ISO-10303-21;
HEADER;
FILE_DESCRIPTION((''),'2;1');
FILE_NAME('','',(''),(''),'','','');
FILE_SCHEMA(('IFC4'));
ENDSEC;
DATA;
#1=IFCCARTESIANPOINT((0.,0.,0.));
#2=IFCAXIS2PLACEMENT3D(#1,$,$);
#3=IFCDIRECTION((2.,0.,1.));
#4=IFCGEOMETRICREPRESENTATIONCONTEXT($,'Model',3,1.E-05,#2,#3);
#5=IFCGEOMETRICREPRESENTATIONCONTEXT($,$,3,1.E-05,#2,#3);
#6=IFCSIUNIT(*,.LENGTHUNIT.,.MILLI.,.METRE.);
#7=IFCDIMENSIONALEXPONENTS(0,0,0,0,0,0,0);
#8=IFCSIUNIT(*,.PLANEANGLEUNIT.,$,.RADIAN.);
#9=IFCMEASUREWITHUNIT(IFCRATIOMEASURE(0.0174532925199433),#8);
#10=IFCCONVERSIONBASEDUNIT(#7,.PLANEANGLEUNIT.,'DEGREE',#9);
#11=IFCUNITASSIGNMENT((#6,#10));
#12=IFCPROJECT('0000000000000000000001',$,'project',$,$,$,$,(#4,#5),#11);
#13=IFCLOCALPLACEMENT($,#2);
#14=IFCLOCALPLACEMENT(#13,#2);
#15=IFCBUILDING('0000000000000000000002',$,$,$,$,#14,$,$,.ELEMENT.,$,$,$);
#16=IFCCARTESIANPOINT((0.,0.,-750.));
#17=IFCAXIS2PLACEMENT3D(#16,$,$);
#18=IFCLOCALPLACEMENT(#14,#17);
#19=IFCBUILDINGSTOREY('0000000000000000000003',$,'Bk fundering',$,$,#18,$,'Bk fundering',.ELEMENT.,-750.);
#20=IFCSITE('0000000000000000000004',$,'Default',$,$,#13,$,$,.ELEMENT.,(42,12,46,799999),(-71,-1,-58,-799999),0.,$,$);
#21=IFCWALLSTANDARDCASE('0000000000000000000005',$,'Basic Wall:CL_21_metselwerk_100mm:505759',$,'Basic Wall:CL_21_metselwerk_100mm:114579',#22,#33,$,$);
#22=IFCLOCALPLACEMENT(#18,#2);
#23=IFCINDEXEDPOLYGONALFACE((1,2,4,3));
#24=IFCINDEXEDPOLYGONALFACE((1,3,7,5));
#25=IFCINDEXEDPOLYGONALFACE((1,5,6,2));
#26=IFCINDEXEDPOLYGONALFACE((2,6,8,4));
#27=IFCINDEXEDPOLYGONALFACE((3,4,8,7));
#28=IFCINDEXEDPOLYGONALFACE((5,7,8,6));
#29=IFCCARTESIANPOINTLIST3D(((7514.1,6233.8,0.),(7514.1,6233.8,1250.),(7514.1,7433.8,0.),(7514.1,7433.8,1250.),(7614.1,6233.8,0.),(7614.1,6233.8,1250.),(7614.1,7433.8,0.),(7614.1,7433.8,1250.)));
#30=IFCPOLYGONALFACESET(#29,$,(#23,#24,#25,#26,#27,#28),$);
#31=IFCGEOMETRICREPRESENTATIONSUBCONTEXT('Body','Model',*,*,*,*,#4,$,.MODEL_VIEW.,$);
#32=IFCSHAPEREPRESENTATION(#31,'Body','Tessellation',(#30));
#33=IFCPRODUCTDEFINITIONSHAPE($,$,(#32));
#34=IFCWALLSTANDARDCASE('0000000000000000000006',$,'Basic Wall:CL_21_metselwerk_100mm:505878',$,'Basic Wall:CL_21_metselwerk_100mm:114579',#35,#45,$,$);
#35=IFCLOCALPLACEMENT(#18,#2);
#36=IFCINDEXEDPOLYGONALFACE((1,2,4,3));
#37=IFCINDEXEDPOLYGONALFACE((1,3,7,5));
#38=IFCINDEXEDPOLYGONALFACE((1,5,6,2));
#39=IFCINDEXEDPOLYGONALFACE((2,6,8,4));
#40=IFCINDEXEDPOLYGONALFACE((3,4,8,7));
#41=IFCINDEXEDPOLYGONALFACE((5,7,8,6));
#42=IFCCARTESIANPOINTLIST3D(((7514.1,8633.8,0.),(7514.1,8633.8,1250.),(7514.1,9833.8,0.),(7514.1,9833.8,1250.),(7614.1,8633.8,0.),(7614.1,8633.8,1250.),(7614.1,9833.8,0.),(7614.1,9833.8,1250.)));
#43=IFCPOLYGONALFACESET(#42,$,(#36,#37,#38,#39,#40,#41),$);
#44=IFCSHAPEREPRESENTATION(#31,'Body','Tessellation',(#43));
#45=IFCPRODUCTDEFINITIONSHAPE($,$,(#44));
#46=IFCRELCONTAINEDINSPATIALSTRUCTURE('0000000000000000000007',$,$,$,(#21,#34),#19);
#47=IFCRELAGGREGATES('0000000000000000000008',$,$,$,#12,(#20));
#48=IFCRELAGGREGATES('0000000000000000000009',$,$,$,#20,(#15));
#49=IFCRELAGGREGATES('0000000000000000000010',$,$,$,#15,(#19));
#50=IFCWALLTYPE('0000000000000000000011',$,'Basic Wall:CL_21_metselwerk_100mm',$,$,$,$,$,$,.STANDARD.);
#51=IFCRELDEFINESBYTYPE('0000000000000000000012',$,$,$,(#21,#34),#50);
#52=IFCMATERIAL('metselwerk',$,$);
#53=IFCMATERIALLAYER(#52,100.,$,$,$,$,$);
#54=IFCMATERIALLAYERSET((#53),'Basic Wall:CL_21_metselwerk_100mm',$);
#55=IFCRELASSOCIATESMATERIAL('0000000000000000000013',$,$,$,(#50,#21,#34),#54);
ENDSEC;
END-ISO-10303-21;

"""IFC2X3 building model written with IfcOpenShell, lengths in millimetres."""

from ifc_helpers import new_model, entity, si_unit, converted_unit, direction, frame, frame_2d, origin, place, context, subcontext, project, spatial, rectangle, extrude, material, layer, layer_set, layer_usage, type_object, element, save


model = new_model("IFC2X3")

# Units and contexts
model_context = context("Model", 3, precision=1e-05, world=origin(), true_north=direction((2.0, 0.0, 1.0)))
context_of_model = context(None, 3, precision=1e-05, world=origin(), true_north=direction((2.0, 0.0, 1.0)))
body_context = subcontext(model_context, "Body", "Model", "MODEL_VIEW")
ifc_project = project(units=[si_unit("LENGTHUNIT", "METRE", prefix="MILLI"), converted_unit("PLANEANGLEUNIT", "DEGREE", entity("IfcRatioMeasure", 0.0174532925199433), si_unit("PLANEANGLEUNIT", "RADIAN"), dimensions=[0, 0, 0, 0, 0, 0, 0])], contexts=[model_context, context_of_model])

# Site, building, storey
site_placement = place(None, origin())
site = spatial("IfcSite", under=ifc_project, at=site_placement, Name="Default", CompositionType="ELEMENT", RefLatitude=(42, 12, 46, 799999), RefLongitude=(-71, -1, -58, -799999), RefElevation=0.0)
building_placement = place(site_placement, origin())
building = spatial("IfcBuilding", under=site, at=building_placement, CompositionType="ELEMENT")
storey_placement = place(building_placement, frame((0.0, 0.0, -750.0)))
storey = spatial("IfcBuildingStorey", under=building, at=storey_placement, Name="Bk fundering", LongName="Bk fundering", CompositionType="ELEMENT", Elevation=-750.0)

# Walls
ifc_material_1 = material(Name="metselwerk")
ifc_layer_1 = layer(ifc_material_1, 100.0)
ifc_layer_set_1 = layer_set([ifc_layer_1], Name="Basic Wall:CL_21_metselwerk_100mm")
wall_type_1 = type_object("IfcWallType", Name="Basic Wall:CL_21_metselwerk_100mm", PredefinedType="STANDARD", material=ifc_layer_set_1)
ifc_layer_usage_1 = layer_usage(ifc_layer_set_1, "AXIS2", "NEGATIVE", 50.0)
wall_1_placement = place(storey_placement, frame((7564.1, 7433.8, 0.0), z_axis=(0.0, 0.0, 1.0), x_axis=(0.0, -1.0, 0.0)))
element("IfcWallStandardCase", 1, at=wall_1_placement, inside=storey, type_object=wall_type_1, material=ifc_layer_usage_1, Name="Basic Wall:CL_21_metselwerk_100mm:505759", ObjectType="Basic Wall:CL_21_metselwerk_100mm:114579", context=body_context, shape_type="SweptSolid", body=[
    extrude(rectangle(XDim=1200.0, YDim=100.0, at=frame_2d((600.0, 0.0), x_axis=(-1.0, 0.0))), origin(), (0.0, 0.0, 1.0), 1250.0),
])
ifc_layer_usage_2 = layer_usage(ifc_layer_set_1, "AXIS2", "NEGATIVE", 50.0)
wall_2_placement = place(storey_placement, frame((7564.1, 9833.8, 0.0), z_axis=(0.0, 0.0, 1.0), x_axis=(0.0, -1.0, 0.0)))
element("IfcWallStandardCase", 2, at=wall_2_placement, inside=storey, type_object=wall_type_1, material=ifc_layer_usage_2, Name="Basic Wall:CL_21_metselwerk_100mm:505878", ObjectType="Basic Wall:CL_21_metselwerk_100mm:114579", context=body_context, shape_type="SweptSolid", body=[
    extrude(rectangle(XDim=1200.0, YDim=100.0, at=frame_2d((600.0, 0.0), x_axis=(-1.0, 0.0))), origin(), (0.0, 0.0, 1.0), 1250.0),
])

save(model, "model.ifc")
